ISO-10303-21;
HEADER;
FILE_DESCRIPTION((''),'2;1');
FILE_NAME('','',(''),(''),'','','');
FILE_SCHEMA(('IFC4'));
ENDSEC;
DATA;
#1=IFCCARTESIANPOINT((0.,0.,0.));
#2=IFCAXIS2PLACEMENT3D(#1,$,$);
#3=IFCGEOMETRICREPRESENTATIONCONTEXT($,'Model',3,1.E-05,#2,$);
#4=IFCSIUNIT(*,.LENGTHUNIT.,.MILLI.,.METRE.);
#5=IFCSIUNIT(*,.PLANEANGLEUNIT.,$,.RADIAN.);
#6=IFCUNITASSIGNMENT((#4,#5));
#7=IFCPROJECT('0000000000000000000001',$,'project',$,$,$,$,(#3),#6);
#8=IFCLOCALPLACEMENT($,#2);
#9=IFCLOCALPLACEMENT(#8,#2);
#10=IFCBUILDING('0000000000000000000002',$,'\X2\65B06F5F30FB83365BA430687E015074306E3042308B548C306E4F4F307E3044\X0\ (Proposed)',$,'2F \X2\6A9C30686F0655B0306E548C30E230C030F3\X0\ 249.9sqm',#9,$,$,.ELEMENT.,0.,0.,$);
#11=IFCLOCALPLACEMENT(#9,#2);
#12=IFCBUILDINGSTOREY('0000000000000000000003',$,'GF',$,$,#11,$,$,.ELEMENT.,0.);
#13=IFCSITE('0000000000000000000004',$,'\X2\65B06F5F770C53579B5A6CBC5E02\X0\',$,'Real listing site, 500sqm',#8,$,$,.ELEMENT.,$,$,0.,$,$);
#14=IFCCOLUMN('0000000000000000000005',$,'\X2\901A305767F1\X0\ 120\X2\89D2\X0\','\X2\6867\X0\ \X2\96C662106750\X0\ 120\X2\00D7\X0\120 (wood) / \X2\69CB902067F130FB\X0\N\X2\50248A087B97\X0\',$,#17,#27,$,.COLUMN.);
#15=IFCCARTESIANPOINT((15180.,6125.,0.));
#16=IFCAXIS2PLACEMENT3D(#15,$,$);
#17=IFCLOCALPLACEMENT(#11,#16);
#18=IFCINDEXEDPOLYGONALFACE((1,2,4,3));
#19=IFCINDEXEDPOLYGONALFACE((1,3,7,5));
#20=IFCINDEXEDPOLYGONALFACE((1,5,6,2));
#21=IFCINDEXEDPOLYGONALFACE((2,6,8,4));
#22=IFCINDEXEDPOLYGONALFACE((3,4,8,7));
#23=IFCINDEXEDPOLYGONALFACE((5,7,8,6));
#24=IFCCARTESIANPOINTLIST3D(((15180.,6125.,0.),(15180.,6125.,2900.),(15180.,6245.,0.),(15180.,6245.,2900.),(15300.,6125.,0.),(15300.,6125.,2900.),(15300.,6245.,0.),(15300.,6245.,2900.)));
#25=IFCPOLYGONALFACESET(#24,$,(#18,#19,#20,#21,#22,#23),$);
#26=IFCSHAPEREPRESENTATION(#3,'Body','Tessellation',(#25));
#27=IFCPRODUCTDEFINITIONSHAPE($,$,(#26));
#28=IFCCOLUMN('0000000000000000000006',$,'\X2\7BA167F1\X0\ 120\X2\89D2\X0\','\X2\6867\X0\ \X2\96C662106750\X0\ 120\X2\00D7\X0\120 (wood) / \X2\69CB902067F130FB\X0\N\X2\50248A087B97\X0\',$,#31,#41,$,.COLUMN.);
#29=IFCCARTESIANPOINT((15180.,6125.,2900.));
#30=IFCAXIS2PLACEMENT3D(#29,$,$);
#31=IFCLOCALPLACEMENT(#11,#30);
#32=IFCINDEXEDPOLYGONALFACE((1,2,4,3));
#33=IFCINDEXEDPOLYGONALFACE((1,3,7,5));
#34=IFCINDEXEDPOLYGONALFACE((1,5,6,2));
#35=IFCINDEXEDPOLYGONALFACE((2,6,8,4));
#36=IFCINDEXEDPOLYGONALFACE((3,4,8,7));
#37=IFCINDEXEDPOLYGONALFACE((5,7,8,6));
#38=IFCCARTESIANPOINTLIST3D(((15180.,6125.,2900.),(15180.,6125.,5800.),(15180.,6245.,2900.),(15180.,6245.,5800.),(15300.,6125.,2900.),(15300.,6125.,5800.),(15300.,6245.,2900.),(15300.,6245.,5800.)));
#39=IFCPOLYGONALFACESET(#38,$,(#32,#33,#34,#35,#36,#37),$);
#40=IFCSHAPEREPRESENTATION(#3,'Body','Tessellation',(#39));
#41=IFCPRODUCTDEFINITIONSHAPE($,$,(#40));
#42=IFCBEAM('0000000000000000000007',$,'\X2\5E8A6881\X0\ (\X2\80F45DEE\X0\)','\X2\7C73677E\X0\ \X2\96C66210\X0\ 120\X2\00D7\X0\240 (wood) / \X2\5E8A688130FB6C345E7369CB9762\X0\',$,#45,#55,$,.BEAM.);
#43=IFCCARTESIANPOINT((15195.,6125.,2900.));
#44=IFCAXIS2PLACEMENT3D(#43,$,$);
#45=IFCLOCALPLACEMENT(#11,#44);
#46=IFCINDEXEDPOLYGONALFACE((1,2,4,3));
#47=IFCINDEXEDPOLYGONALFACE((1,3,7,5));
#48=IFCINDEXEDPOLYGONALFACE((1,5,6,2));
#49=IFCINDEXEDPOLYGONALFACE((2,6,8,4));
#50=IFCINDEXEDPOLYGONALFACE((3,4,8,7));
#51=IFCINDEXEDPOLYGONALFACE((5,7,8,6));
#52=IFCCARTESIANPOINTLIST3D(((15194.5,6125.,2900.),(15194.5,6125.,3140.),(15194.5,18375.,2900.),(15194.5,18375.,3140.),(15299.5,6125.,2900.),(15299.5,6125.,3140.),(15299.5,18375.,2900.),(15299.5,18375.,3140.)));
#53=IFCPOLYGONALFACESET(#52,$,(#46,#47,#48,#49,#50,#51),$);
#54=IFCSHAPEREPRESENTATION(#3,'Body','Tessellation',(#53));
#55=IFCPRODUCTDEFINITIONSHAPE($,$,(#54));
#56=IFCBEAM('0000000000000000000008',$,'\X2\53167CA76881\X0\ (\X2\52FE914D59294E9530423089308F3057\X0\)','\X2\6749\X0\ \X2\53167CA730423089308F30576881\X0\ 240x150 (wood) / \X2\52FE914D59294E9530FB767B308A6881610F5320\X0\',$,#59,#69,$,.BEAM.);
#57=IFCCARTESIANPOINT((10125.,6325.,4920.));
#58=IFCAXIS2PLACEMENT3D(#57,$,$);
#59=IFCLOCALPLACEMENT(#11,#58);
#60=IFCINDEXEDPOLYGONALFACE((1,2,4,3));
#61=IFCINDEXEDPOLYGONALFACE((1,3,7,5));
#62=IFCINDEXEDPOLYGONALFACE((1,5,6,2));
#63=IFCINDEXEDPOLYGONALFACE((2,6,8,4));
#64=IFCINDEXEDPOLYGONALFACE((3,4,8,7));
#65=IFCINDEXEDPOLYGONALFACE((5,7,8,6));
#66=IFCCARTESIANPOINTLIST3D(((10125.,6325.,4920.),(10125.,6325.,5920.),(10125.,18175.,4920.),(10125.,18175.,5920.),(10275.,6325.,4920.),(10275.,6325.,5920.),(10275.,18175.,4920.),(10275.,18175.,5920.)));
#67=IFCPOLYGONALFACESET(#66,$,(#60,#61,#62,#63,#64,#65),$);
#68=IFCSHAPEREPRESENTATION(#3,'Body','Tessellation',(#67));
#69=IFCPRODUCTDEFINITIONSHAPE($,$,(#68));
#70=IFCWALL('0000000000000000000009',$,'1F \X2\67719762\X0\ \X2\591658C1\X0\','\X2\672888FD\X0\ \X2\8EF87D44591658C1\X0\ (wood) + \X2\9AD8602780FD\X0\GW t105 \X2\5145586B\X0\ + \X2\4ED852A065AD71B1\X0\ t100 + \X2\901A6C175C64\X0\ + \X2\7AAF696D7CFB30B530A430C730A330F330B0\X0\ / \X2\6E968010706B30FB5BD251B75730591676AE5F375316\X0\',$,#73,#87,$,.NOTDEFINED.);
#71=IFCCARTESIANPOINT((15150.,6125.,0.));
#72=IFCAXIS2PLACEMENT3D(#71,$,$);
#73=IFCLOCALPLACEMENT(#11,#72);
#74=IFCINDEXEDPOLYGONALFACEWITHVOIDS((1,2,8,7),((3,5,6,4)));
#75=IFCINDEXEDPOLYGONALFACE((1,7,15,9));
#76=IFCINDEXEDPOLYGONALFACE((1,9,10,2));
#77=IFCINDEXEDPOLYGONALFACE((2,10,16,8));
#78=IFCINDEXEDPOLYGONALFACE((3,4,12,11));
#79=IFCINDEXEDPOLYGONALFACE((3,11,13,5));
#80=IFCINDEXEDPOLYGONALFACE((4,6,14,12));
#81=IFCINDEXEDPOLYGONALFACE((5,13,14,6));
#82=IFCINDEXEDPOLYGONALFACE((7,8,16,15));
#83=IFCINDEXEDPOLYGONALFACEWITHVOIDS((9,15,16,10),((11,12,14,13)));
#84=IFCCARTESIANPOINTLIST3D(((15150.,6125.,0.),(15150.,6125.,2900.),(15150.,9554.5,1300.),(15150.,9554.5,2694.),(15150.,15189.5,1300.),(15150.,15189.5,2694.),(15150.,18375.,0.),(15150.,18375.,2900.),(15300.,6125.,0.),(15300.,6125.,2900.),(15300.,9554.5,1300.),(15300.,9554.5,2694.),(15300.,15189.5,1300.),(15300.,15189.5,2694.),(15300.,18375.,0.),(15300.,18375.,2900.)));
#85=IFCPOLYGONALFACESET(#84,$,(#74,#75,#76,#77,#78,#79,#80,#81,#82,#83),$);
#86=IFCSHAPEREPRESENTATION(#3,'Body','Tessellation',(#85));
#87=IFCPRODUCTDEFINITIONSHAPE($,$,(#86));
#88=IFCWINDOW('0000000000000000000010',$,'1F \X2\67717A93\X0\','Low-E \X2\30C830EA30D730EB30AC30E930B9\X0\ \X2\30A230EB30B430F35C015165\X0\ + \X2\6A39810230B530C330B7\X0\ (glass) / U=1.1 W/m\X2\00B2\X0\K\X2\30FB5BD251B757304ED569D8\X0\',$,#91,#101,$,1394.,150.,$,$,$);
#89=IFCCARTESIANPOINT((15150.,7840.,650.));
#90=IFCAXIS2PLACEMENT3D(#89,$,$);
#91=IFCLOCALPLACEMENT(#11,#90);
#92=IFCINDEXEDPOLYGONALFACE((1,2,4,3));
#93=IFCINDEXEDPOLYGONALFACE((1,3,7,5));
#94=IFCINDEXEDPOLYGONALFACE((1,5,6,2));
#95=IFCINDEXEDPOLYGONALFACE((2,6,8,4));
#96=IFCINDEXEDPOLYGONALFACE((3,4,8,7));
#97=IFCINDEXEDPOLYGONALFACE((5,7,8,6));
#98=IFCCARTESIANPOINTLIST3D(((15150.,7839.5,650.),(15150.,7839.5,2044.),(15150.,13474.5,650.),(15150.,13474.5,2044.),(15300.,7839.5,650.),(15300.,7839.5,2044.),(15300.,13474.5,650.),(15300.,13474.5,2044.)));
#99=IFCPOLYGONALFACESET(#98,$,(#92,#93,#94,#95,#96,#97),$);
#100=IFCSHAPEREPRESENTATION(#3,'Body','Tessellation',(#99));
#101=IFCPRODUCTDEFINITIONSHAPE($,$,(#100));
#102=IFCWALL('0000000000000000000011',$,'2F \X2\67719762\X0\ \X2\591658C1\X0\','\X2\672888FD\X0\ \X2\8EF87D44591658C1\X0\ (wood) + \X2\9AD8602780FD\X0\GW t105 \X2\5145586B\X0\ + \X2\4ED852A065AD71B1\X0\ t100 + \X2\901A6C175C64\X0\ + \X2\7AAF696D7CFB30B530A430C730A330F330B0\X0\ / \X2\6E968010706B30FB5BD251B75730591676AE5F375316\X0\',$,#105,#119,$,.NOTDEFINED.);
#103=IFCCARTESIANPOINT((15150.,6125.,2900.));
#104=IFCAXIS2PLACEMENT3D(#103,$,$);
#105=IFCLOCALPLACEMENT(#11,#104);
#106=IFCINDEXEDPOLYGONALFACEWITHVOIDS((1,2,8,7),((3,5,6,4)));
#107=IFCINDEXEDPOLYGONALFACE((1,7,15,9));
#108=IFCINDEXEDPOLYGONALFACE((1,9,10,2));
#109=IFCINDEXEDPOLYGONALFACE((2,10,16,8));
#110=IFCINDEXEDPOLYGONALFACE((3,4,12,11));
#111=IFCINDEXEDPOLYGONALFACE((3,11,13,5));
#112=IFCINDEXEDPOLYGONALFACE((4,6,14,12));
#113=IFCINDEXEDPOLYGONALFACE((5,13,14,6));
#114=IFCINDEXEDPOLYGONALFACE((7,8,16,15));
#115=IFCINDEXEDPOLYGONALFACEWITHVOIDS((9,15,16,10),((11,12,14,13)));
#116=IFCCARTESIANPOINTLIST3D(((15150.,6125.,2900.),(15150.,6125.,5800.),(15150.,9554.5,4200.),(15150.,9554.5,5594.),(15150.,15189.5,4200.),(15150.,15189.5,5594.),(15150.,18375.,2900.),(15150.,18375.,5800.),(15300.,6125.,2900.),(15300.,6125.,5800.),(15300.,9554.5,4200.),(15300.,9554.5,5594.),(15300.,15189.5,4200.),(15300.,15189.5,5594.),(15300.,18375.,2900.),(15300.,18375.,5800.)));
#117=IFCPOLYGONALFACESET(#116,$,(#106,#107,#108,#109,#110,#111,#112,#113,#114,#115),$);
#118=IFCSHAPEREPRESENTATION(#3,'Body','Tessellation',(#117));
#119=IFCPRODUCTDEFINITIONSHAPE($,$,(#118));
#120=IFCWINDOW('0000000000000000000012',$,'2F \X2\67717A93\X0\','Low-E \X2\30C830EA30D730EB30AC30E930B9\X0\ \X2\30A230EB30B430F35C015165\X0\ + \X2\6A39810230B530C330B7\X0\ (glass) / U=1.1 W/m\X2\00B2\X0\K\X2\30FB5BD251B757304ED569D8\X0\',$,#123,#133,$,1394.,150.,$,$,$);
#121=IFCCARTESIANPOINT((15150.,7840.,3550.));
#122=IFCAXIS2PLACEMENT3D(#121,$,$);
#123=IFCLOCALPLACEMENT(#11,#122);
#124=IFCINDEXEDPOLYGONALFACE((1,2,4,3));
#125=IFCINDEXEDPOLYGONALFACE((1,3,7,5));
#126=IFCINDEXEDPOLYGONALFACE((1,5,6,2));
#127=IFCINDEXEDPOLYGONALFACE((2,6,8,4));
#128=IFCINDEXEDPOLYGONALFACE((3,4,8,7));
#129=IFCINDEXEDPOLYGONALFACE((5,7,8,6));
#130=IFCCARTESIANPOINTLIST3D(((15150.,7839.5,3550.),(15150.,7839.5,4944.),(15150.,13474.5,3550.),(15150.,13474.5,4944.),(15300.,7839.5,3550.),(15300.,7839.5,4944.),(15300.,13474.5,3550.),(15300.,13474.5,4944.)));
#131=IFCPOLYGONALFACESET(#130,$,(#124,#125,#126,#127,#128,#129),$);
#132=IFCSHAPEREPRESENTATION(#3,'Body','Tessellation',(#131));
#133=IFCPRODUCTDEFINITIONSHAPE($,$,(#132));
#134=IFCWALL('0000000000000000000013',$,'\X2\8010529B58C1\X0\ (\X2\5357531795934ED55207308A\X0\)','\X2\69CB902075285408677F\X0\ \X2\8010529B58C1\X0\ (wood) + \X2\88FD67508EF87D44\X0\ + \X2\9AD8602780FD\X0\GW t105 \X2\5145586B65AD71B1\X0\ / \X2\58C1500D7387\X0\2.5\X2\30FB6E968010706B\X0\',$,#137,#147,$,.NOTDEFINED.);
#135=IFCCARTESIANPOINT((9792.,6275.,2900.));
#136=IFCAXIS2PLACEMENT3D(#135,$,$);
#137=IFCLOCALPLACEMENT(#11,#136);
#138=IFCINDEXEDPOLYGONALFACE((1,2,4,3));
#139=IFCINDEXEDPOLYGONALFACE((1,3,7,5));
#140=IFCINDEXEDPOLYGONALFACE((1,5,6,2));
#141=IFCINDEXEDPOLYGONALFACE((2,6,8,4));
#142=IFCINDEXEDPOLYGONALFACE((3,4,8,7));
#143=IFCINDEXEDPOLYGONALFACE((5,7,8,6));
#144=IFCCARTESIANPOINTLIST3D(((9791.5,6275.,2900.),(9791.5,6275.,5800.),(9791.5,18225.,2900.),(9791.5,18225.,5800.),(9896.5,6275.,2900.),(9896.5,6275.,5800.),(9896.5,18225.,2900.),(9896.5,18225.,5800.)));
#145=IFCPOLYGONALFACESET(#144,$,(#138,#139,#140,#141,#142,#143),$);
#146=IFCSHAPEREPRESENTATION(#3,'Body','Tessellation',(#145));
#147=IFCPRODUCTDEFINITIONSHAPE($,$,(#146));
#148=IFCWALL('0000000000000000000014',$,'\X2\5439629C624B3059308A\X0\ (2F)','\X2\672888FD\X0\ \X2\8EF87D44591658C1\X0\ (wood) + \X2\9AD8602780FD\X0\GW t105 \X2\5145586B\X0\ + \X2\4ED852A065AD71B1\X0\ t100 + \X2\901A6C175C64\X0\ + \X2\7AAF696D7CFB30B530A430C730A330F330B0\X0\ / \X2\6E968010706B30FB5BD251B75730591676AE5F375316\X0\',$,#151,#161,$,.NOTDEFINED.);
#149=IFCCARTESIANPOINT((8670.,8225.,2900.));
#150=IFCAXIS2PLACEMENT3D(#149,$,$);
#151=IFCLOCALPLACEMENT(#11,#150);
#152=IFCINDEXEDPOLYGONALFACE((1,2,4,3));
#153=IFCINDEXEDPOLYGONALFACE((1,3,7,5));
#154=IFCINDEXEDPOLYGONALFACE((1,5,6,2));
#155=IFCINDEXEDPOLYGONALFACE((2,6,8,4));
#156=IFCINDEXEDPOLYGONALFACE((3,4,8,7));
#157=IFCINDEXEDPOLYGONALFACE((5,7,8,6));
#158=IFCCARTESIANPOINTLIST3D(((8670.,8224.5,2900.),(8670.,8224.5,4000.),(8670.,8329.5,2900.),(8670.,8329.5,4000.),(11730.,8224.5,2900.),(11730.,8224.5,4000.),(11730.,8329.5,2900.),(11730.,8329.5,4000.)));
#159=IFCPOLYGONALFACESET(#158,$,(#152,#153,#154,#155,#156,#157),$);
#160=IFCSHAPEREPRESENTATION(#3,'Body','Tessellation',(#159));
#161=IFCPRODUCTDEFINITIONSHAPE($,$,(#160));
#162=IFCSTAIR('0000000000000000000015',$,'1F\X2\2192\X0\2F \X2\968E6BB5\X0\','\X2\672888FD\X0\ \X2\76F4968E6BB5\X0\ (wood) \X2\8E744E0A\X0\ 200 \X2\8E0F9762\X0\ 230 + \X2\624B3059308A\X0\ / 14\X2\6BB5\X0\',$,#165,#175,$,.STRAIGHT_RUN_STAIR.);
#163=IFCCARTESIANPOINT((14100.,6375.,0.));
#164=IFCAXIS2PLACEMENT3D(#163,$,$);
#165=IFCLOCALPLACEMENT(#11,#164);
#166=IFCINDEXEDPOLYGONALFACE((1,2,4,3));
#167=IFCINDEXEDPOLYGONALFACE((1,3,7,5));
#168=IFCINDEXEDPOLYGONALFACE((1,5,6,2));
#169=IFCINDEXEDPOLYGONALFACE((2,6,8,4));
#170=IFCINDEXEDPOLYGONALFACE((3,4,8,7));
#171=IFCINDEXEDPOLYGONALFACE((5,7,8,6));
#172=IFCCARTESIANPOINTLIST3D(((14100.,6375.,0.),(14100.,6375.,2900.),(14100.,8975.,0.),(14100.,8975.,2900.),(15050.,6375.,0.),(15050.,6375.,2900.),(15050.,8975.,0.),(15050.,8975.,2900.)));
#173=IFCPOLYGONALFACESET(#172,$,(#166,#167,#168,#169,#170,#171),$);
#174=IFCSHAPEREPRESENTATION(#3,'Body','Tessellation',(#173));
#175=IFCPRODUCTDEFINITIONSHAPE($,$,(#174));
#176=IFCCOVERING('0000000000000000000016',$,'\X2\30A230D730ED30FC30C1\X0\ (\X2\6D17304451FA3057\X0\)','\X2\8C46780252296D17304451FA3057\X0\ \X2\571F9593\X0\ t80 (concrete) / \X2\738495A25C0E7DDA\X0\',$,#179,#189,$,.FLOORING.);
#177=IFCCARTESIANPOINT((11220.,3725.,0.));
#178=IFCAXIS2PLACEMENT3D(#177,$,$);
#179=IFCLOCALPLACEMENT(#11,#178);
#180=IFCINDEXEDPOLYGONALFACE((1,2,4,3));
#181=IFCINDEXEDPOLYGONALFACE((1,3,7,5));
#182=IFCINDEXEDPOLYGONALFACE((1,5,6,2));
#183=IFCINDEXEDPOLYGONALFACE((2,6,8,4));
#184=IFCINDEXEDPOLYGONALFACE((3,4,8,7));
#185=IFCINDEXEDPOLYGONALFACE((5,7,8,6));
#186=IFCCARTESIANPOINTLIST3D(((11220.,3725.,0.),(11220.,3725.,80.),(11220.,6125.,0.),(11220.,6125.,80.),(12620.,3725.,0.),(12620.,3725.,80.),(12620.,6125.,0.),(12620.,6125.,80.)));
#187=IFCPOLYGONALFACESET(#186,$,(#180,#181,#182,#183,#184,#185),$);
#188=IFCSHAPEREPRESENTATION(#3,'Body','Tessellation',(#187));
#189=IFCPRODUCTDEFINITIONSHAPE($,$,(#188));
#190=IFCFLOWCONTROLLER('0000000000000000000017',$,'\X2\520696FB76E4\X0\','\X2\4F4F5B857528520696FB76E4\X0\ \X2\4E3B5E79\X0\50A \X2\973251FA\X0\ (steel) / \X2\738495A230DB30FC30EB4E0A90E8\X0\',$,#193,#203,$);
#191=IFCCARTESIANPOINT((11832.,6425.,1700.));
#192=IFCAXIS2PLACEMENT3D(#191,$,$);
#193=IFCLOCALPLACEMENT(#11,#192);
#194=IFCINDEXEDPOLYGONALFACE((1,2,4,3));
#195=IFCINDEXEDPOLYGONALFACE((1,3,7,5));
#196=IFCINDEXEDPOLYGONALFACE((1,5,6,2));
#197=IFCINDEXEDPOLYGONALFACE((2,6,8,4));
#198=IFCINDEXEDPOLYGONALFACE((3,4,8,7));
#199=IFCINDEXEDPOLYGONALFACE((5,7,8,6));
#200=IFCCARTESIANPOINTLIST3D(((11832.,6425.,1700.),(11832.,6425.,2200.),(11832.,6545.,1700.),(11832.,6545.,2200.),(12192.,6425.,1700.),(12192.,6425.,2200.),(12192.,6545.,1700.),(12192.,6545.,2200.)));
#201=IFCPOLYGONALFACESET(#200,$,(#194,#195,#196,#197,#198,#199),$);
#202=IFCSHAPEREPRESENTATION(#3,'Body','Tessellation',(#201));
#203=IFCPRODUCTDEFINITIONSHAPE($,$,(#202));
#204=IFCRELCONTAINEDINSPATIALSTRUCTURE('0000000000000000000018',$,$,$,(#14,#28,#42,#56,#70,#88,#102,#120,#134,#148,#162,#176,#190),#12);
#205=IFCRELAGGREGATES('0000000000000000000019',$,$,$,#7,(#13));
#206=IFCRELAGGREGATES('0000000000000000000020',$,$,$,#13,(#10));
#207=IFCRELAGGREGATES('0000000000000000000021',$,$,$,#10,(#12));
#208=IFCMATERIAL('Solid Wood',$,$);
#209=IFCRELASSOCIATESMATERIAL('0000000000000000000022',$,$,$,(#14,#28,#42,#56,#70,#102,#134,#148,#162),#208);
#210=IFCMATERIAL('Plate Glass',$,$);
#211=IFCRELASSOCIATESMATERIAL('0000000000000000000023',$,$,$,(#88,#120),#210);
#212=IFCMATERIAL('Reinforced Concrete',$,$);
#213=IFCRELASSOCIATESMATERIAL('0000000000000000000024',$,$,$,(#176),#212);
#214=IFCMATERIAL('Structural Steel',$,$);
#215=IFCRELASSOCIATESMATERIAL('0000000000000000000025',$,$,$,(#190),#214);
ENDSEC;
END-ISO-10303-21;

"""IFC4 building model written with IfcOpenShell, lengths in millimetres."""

from ifc_helpers import new_model, si_unit, frame, frame_2d, origin, place, context, project, spatial, rectangle, extrude, material, element, fill, save


model = new_model("IFC4")

# Units and contexts
model_context = context("Model", 3, precision=1e-05, world=origin())
ifc_project = project(units=[si_unit("LENGTHUNIT", "METRE", prefix="MILLI"), si_unit("PLANEANGLEUNIT", "RADIAN")], contexts=[model_context])

# Site, building, storey
site_placement = place(None, origin())
site = spatial("IfcSite", under=ifc_project, at=site_placement, Name="新潟県南魚沼市", ObjectType="Real listing site, 500sqm", CompositionType="ELEMENT", RefElevation=0.0)
building_placement = place(site_placement, origin())
building = spatial("IfcBuilding", under=site, at=building_placement, Name="新潟・茶室と縁側のある和の住まい (Proposed)", ObjectType="2F 檜と漆喰の和モダン 249.9sqm", CompositionType="ELEMENT", ElevationOfRefHeight=0.0, ElevationOfTerrain=0.0)
storey_placement = place(building_placement, origin())
storey = spatial("IfcBuildingStorey", under=building, at=storey_placement, Name="GF", CompositionType="ELEMENT", Elevation=0.0)

# Columns
ifc_material_1 = material(Name="Solid Wood")
column_1_placement = place(storey_placement, frame((15180.0, 6125.0, 0.0)))
element("IfcColumn", 1, at=column_1_placement, inside=storey, material=ifc_material_1, Name="通し柱 120角", Description="桧 集成材 120×120 (wood) / 構造柱・N値計算", PredefinedType="COLUMN", context=model_context, shape_type="SweptSolid", body=[
    extrude(rectangle(XDim=120.0, YDim=120.0, at=frame_2d((60.0, 60.0))), frame((15180.0, 6125.0, 0.0)), (0.0, 0.0, 1.0), 2900.0),
])
column_2_placement = place(storey_placement, frame((15180.0, 6125.0, 2900.0)))
element("IfcColumn", 2, at=column_2_placement, inside=storey, material=ifc_material_1, Name="管柱 120角", Description="桧 集成材 120×120 (wood) / 構造柱・N値計算", PredefinedType="COLUMN", context=model_context, shape_type="SweptSolid", body=[
    extrude(rectangle(XDim=120.0, YDim=120.0, at=frame_2d((60.0, 60.0))), frame((15180.0, 6125.0, 2900.0)), (0.0, 0.0, 1.0), 2900.0),
])

# Beams
beam_1_placement = place(storey_placement, frame((15195.0, 6125.0, 2900.0)))
element("IfcBeam", 3, at=beam_1_placement, inside=storey, material=ifc_material_1, Name="床梁 (胴差)", Description="米松 集成 120×240 (wood) / 床梁・水平構面", PredefinedType="BEAM", context=model_context, shape_type="SweptSolid", body=[
    extrude(rectangle(XDim=105.0, YDim=12250.0, at=frame_2d((52.0, 6125.0))), frame((15195.0, 6125.0, 2900.0)), (0.0, 0.0, 1.0), 240.0),
])
beam_2_placement = place(storey_placement, frame((10125.0, 6325.0, 4920.0)))
element("IfcBeam", 4, at=beam_2_placement, inside=storey, material=ifc_material_1, Name="化粧梁 (勾配天井あらわし)", Description="杉 化粧あらわし梁 240x150 (wood) / 勾配天井・登り梁意匠", PredefinedType="BEAM", context=model_context, shape_type="SweptSolid", body=[
    extrude(rectangle(XDim=150.0, YDim=11850.0, at=frame_2d((75.0, 5925.0))), frame((10125.0, 6325.0, 4920.0)), (0.0, 0.0, 1.0), 1000.0),
])

# Wall, opening, window
wall_1_placement = place(storey_placement, frame((15150.0, 6125.0, 0.0)))
wall_1 = element("IfcWall", 5, at=wall_1_placement, inside=storey, material=ifc_material_1, Name="1F 東面 外壁", Description="木製 軸組外壁 (wood) + 高性能GW t105 充填 + 付加断熱 t100 + 通気層 + 窯業系サイディング / 準耐火・寒冷地外皮強化", PredefinedType="NOTDEFINED", context=model_context, shape_type="SweptSolid", body=[
    extrude(rectangle(XDim=150.0, YDim=12250.0, at=frame_2d((75.0, 6125.0))), frame((15150.0, 6125.0, 0.0)), (0.0, 0.0, 1.0), 2900.0),
])
opening_1_placement = place(storey_placement, frame((15150.0, 7840.0, 650.0)))
opening_1 = element("IfcOpeningElement", 6, at=opening_1_placement, cuts=wall_1, PredefinedType="NOTDEFINED", context=model_context, shape_type="SweptSolid", body=[
    extrude(rectangle(XDim=150.0, YDim=5635.0, at=frame_2d((75.0, 2817.0))), frame((15150.0, 7840.0, 650.0)), (0.0, 0.0, 1.0), 1394.0),
])
ifc_material_2 = material(Name="Plate Glass")
window_1_placement = place(storey_placement, frame((15150.0, 7840.0, 650.0)))
window_1 = element("IfcWindow", 7, at=window_1_placement, inside=storey, material=ifc_material_2, Name="1F 東窓", Description="Low-E トリプルガラス アルゴン封入 + 樹脂サッシ (glass) / U=1.1 W/m²K・寒冷地仕様", OverallHeight=1394.0, OverallWidth=150.0, context=model_context, shape_type="SweptSolid", body=[
    extrude(rectangle(XDim=150.0, YDim=5635.0, at=frame_2d((75.0, 2817.0))), frame((15150.0, 7840.0, 650.0)), (0.0, 0.0, 1.0), 1394.0),
])
fill(opening_1, window_1)

# Wall, opening, window
wall_2_placement = place(storey_placement, frame((15150.0, 6125.0, 2900.0)))
wall_2 = element("IfcWall", 8, at=wall_2_placement, inside=storey, material=ifc_material_1, Name="2F 東面 外壁", Description="木製 軸組外壁 (wood) + 高性能GW t105 充填 + 付加断熱 t100 + 通気層 + 窯業系サイディング / 準耐火・寒冷地外皮強化", PredefinedType="NOTDEFINED", context=model_context, shape_type="SweptSolid", body=[
    extrude(rectangle(XDim=150.0, YDim=12250.0, at=frame_2d((75.0, 6125.0))), frame((15150.0, 6125.0, 2900.0)), (0.0, 0.0, 1.0), 2900.0),
])
opening_2_placement = place(storey_placement, frame((15150.0, 7840.0, 3550.0)))
opening_2 = element("IfcOpeningElement", 9, at=opening_2_placement, cuts=wall_2, PredefinedType="NOTDEFINED", context=model_context, shape_type="SweptSolid", body=[
    extrude(rectangle(XDim=150.0, YDim=5635.0, at=frame_2d((75.0, 2817.0))), frame((15150.0, 7840.0, 3550.0)), (0.0, 0.0, 1.0), 1394.0),
])
window_2_placement = place(storey_placement, frame((15150.0, 7840.0, 3550.0)))
window_2 = element("IfcWindow", 10, at=window_2_placement, inside=storey, material=ifc_material_2, Name="2F 東窓", Description="Low-E トリプルガラス アルゴン封入 + 樹脂サッシ (glass) / U=1.1 W/m²K・寒冷地仕様", OverallHeight=1394.0, OverallWidth=150.0, context=model_context, shape_type="SweptSolid", body=[
    extrude(rectangle(XDim=150.0, YDim=5635.0, at=frame_2d((75.0, 2817.0))), frame((15150.0, 7840.0, 3550.0)), (0.0, 0.0, 1.0), 1394.0),
])
fill(opening_2, window_2)

# Walls
wall_3_placement = place(storey_placement, frame((9792.0, 6275.0, 2900.0)))
element("IfcWall", 11, at=wall_3_placement, inside=storey, material=ifc_material_1, Name="耐力壁 (南北間仕切り)", Description="構造用合板 耐力壁 (wood) + 製材軸組 + 高性能GW t105 充填断熱 / 壁倍率2.5・準耐火", PredefinedType="NOTDEFINED", context=model_context, shape_type="SweptSolid", body=[
    extrude(rectangle(XDim=105.0, YDim=11950.0, at=frame_2d((52.0, 5975.0))), frame((9792.0, 6275.0, 2900.0)), (0.0, 0.0, 1.0), 2900.0),
])
wall_4_placement = place(storey_placement, frame((8670.0, 8225.0, 2900.0)))
element("IfcWall", 12, at=wall_4_placement, inside=storey, material=ifc_material_1, Name="吹抜手すり (2F)", Description="木製 軸組外壁 (wood) + 高性能GW t105 充填 + 付加断熱 t100 + 通気層 + 窯業系サイディング / 準耐火・寒冷地外皮強化", PredefinedType="NOTDEFINED", context=model_context, shape_type="SweptSolid", body=[
    extrude(rectangle(XDim=3060.0, YDim=105.0, at=frame_2d((1530.0, 52.0))), frame((8670.0, 8225.0, 2900.0)), (0.0, 0.0, 1.0), 1100.0),
])

# Stair
stair_placement = place(storey_placement, frame((14100.0, 6375.0, 0.0)))
element("IfcStair", 13, at=stair_placement, inside=storey, material=ifc_material_1, Name="1F→2F 階段", Description="木製 直階段 (wood) 蹴上 200 踏面 230 + 手すり / 14段", PredefinedType="STRAIGHT_RUN_STAIR", context=model_context, shape_type="SweptSolid", body=[
    extrude(rectangle(XDim=950.0, YDim=2600.0, at=frame_2d((475.0, 1300.0))), frame((14100.0, 6375.0, 0.0)), (0.0, 0.0, 1.0), 2900.0),
])

# Covering
ifc_material_3 = material(Name="Reinforced Concrete")
covering_placement = place(storey_placement, frame((11220.0, 3725.0, 0.0)))
element("IfcCovering", 14, at=covering_placement, inside=storey, material=ifc_material_3, Name="アプローチ (洗い出し)", Description="豆砂利洗い出し 土間 t80 (concrete) / 玄関導線", PredefinedType="FLOORING", context=model_context, shape_type="SweptSolid", body=[
    extrude(rectangle(XDim=1400.0, YDim=2400.0, at=frame_2d((700.0, 1200.0))), frame((11220.0, 3725.0, 0.0)), (0.0, 0.0, 1.0), 80.0),
])

# Flow controller
ifc_material_4 = material(Name="Structural Steel")
flow_controller_placement = place(storey_placement, frame((11832.0, 6425.0, 1700.0)))
element("IfcFlowController", 15, at=flow_controller_placement, inside=storey, material=ifc_material_4, Name="分電盤", Description="住宅用分電盤 主幹50A 露出 (steel) / 玄関ホール上部", context=model_context, shape_type="SweptSolid", body=[
    extrude(rectangle(XDim=360.0, YDim=120.0, at=frame_2d((180.0, 60.0))), frame((11832.0, 6425.0, 1700.0)), (0.0, 0.0, 1.0), 500.0),
])

save(model, "model.ifc")
